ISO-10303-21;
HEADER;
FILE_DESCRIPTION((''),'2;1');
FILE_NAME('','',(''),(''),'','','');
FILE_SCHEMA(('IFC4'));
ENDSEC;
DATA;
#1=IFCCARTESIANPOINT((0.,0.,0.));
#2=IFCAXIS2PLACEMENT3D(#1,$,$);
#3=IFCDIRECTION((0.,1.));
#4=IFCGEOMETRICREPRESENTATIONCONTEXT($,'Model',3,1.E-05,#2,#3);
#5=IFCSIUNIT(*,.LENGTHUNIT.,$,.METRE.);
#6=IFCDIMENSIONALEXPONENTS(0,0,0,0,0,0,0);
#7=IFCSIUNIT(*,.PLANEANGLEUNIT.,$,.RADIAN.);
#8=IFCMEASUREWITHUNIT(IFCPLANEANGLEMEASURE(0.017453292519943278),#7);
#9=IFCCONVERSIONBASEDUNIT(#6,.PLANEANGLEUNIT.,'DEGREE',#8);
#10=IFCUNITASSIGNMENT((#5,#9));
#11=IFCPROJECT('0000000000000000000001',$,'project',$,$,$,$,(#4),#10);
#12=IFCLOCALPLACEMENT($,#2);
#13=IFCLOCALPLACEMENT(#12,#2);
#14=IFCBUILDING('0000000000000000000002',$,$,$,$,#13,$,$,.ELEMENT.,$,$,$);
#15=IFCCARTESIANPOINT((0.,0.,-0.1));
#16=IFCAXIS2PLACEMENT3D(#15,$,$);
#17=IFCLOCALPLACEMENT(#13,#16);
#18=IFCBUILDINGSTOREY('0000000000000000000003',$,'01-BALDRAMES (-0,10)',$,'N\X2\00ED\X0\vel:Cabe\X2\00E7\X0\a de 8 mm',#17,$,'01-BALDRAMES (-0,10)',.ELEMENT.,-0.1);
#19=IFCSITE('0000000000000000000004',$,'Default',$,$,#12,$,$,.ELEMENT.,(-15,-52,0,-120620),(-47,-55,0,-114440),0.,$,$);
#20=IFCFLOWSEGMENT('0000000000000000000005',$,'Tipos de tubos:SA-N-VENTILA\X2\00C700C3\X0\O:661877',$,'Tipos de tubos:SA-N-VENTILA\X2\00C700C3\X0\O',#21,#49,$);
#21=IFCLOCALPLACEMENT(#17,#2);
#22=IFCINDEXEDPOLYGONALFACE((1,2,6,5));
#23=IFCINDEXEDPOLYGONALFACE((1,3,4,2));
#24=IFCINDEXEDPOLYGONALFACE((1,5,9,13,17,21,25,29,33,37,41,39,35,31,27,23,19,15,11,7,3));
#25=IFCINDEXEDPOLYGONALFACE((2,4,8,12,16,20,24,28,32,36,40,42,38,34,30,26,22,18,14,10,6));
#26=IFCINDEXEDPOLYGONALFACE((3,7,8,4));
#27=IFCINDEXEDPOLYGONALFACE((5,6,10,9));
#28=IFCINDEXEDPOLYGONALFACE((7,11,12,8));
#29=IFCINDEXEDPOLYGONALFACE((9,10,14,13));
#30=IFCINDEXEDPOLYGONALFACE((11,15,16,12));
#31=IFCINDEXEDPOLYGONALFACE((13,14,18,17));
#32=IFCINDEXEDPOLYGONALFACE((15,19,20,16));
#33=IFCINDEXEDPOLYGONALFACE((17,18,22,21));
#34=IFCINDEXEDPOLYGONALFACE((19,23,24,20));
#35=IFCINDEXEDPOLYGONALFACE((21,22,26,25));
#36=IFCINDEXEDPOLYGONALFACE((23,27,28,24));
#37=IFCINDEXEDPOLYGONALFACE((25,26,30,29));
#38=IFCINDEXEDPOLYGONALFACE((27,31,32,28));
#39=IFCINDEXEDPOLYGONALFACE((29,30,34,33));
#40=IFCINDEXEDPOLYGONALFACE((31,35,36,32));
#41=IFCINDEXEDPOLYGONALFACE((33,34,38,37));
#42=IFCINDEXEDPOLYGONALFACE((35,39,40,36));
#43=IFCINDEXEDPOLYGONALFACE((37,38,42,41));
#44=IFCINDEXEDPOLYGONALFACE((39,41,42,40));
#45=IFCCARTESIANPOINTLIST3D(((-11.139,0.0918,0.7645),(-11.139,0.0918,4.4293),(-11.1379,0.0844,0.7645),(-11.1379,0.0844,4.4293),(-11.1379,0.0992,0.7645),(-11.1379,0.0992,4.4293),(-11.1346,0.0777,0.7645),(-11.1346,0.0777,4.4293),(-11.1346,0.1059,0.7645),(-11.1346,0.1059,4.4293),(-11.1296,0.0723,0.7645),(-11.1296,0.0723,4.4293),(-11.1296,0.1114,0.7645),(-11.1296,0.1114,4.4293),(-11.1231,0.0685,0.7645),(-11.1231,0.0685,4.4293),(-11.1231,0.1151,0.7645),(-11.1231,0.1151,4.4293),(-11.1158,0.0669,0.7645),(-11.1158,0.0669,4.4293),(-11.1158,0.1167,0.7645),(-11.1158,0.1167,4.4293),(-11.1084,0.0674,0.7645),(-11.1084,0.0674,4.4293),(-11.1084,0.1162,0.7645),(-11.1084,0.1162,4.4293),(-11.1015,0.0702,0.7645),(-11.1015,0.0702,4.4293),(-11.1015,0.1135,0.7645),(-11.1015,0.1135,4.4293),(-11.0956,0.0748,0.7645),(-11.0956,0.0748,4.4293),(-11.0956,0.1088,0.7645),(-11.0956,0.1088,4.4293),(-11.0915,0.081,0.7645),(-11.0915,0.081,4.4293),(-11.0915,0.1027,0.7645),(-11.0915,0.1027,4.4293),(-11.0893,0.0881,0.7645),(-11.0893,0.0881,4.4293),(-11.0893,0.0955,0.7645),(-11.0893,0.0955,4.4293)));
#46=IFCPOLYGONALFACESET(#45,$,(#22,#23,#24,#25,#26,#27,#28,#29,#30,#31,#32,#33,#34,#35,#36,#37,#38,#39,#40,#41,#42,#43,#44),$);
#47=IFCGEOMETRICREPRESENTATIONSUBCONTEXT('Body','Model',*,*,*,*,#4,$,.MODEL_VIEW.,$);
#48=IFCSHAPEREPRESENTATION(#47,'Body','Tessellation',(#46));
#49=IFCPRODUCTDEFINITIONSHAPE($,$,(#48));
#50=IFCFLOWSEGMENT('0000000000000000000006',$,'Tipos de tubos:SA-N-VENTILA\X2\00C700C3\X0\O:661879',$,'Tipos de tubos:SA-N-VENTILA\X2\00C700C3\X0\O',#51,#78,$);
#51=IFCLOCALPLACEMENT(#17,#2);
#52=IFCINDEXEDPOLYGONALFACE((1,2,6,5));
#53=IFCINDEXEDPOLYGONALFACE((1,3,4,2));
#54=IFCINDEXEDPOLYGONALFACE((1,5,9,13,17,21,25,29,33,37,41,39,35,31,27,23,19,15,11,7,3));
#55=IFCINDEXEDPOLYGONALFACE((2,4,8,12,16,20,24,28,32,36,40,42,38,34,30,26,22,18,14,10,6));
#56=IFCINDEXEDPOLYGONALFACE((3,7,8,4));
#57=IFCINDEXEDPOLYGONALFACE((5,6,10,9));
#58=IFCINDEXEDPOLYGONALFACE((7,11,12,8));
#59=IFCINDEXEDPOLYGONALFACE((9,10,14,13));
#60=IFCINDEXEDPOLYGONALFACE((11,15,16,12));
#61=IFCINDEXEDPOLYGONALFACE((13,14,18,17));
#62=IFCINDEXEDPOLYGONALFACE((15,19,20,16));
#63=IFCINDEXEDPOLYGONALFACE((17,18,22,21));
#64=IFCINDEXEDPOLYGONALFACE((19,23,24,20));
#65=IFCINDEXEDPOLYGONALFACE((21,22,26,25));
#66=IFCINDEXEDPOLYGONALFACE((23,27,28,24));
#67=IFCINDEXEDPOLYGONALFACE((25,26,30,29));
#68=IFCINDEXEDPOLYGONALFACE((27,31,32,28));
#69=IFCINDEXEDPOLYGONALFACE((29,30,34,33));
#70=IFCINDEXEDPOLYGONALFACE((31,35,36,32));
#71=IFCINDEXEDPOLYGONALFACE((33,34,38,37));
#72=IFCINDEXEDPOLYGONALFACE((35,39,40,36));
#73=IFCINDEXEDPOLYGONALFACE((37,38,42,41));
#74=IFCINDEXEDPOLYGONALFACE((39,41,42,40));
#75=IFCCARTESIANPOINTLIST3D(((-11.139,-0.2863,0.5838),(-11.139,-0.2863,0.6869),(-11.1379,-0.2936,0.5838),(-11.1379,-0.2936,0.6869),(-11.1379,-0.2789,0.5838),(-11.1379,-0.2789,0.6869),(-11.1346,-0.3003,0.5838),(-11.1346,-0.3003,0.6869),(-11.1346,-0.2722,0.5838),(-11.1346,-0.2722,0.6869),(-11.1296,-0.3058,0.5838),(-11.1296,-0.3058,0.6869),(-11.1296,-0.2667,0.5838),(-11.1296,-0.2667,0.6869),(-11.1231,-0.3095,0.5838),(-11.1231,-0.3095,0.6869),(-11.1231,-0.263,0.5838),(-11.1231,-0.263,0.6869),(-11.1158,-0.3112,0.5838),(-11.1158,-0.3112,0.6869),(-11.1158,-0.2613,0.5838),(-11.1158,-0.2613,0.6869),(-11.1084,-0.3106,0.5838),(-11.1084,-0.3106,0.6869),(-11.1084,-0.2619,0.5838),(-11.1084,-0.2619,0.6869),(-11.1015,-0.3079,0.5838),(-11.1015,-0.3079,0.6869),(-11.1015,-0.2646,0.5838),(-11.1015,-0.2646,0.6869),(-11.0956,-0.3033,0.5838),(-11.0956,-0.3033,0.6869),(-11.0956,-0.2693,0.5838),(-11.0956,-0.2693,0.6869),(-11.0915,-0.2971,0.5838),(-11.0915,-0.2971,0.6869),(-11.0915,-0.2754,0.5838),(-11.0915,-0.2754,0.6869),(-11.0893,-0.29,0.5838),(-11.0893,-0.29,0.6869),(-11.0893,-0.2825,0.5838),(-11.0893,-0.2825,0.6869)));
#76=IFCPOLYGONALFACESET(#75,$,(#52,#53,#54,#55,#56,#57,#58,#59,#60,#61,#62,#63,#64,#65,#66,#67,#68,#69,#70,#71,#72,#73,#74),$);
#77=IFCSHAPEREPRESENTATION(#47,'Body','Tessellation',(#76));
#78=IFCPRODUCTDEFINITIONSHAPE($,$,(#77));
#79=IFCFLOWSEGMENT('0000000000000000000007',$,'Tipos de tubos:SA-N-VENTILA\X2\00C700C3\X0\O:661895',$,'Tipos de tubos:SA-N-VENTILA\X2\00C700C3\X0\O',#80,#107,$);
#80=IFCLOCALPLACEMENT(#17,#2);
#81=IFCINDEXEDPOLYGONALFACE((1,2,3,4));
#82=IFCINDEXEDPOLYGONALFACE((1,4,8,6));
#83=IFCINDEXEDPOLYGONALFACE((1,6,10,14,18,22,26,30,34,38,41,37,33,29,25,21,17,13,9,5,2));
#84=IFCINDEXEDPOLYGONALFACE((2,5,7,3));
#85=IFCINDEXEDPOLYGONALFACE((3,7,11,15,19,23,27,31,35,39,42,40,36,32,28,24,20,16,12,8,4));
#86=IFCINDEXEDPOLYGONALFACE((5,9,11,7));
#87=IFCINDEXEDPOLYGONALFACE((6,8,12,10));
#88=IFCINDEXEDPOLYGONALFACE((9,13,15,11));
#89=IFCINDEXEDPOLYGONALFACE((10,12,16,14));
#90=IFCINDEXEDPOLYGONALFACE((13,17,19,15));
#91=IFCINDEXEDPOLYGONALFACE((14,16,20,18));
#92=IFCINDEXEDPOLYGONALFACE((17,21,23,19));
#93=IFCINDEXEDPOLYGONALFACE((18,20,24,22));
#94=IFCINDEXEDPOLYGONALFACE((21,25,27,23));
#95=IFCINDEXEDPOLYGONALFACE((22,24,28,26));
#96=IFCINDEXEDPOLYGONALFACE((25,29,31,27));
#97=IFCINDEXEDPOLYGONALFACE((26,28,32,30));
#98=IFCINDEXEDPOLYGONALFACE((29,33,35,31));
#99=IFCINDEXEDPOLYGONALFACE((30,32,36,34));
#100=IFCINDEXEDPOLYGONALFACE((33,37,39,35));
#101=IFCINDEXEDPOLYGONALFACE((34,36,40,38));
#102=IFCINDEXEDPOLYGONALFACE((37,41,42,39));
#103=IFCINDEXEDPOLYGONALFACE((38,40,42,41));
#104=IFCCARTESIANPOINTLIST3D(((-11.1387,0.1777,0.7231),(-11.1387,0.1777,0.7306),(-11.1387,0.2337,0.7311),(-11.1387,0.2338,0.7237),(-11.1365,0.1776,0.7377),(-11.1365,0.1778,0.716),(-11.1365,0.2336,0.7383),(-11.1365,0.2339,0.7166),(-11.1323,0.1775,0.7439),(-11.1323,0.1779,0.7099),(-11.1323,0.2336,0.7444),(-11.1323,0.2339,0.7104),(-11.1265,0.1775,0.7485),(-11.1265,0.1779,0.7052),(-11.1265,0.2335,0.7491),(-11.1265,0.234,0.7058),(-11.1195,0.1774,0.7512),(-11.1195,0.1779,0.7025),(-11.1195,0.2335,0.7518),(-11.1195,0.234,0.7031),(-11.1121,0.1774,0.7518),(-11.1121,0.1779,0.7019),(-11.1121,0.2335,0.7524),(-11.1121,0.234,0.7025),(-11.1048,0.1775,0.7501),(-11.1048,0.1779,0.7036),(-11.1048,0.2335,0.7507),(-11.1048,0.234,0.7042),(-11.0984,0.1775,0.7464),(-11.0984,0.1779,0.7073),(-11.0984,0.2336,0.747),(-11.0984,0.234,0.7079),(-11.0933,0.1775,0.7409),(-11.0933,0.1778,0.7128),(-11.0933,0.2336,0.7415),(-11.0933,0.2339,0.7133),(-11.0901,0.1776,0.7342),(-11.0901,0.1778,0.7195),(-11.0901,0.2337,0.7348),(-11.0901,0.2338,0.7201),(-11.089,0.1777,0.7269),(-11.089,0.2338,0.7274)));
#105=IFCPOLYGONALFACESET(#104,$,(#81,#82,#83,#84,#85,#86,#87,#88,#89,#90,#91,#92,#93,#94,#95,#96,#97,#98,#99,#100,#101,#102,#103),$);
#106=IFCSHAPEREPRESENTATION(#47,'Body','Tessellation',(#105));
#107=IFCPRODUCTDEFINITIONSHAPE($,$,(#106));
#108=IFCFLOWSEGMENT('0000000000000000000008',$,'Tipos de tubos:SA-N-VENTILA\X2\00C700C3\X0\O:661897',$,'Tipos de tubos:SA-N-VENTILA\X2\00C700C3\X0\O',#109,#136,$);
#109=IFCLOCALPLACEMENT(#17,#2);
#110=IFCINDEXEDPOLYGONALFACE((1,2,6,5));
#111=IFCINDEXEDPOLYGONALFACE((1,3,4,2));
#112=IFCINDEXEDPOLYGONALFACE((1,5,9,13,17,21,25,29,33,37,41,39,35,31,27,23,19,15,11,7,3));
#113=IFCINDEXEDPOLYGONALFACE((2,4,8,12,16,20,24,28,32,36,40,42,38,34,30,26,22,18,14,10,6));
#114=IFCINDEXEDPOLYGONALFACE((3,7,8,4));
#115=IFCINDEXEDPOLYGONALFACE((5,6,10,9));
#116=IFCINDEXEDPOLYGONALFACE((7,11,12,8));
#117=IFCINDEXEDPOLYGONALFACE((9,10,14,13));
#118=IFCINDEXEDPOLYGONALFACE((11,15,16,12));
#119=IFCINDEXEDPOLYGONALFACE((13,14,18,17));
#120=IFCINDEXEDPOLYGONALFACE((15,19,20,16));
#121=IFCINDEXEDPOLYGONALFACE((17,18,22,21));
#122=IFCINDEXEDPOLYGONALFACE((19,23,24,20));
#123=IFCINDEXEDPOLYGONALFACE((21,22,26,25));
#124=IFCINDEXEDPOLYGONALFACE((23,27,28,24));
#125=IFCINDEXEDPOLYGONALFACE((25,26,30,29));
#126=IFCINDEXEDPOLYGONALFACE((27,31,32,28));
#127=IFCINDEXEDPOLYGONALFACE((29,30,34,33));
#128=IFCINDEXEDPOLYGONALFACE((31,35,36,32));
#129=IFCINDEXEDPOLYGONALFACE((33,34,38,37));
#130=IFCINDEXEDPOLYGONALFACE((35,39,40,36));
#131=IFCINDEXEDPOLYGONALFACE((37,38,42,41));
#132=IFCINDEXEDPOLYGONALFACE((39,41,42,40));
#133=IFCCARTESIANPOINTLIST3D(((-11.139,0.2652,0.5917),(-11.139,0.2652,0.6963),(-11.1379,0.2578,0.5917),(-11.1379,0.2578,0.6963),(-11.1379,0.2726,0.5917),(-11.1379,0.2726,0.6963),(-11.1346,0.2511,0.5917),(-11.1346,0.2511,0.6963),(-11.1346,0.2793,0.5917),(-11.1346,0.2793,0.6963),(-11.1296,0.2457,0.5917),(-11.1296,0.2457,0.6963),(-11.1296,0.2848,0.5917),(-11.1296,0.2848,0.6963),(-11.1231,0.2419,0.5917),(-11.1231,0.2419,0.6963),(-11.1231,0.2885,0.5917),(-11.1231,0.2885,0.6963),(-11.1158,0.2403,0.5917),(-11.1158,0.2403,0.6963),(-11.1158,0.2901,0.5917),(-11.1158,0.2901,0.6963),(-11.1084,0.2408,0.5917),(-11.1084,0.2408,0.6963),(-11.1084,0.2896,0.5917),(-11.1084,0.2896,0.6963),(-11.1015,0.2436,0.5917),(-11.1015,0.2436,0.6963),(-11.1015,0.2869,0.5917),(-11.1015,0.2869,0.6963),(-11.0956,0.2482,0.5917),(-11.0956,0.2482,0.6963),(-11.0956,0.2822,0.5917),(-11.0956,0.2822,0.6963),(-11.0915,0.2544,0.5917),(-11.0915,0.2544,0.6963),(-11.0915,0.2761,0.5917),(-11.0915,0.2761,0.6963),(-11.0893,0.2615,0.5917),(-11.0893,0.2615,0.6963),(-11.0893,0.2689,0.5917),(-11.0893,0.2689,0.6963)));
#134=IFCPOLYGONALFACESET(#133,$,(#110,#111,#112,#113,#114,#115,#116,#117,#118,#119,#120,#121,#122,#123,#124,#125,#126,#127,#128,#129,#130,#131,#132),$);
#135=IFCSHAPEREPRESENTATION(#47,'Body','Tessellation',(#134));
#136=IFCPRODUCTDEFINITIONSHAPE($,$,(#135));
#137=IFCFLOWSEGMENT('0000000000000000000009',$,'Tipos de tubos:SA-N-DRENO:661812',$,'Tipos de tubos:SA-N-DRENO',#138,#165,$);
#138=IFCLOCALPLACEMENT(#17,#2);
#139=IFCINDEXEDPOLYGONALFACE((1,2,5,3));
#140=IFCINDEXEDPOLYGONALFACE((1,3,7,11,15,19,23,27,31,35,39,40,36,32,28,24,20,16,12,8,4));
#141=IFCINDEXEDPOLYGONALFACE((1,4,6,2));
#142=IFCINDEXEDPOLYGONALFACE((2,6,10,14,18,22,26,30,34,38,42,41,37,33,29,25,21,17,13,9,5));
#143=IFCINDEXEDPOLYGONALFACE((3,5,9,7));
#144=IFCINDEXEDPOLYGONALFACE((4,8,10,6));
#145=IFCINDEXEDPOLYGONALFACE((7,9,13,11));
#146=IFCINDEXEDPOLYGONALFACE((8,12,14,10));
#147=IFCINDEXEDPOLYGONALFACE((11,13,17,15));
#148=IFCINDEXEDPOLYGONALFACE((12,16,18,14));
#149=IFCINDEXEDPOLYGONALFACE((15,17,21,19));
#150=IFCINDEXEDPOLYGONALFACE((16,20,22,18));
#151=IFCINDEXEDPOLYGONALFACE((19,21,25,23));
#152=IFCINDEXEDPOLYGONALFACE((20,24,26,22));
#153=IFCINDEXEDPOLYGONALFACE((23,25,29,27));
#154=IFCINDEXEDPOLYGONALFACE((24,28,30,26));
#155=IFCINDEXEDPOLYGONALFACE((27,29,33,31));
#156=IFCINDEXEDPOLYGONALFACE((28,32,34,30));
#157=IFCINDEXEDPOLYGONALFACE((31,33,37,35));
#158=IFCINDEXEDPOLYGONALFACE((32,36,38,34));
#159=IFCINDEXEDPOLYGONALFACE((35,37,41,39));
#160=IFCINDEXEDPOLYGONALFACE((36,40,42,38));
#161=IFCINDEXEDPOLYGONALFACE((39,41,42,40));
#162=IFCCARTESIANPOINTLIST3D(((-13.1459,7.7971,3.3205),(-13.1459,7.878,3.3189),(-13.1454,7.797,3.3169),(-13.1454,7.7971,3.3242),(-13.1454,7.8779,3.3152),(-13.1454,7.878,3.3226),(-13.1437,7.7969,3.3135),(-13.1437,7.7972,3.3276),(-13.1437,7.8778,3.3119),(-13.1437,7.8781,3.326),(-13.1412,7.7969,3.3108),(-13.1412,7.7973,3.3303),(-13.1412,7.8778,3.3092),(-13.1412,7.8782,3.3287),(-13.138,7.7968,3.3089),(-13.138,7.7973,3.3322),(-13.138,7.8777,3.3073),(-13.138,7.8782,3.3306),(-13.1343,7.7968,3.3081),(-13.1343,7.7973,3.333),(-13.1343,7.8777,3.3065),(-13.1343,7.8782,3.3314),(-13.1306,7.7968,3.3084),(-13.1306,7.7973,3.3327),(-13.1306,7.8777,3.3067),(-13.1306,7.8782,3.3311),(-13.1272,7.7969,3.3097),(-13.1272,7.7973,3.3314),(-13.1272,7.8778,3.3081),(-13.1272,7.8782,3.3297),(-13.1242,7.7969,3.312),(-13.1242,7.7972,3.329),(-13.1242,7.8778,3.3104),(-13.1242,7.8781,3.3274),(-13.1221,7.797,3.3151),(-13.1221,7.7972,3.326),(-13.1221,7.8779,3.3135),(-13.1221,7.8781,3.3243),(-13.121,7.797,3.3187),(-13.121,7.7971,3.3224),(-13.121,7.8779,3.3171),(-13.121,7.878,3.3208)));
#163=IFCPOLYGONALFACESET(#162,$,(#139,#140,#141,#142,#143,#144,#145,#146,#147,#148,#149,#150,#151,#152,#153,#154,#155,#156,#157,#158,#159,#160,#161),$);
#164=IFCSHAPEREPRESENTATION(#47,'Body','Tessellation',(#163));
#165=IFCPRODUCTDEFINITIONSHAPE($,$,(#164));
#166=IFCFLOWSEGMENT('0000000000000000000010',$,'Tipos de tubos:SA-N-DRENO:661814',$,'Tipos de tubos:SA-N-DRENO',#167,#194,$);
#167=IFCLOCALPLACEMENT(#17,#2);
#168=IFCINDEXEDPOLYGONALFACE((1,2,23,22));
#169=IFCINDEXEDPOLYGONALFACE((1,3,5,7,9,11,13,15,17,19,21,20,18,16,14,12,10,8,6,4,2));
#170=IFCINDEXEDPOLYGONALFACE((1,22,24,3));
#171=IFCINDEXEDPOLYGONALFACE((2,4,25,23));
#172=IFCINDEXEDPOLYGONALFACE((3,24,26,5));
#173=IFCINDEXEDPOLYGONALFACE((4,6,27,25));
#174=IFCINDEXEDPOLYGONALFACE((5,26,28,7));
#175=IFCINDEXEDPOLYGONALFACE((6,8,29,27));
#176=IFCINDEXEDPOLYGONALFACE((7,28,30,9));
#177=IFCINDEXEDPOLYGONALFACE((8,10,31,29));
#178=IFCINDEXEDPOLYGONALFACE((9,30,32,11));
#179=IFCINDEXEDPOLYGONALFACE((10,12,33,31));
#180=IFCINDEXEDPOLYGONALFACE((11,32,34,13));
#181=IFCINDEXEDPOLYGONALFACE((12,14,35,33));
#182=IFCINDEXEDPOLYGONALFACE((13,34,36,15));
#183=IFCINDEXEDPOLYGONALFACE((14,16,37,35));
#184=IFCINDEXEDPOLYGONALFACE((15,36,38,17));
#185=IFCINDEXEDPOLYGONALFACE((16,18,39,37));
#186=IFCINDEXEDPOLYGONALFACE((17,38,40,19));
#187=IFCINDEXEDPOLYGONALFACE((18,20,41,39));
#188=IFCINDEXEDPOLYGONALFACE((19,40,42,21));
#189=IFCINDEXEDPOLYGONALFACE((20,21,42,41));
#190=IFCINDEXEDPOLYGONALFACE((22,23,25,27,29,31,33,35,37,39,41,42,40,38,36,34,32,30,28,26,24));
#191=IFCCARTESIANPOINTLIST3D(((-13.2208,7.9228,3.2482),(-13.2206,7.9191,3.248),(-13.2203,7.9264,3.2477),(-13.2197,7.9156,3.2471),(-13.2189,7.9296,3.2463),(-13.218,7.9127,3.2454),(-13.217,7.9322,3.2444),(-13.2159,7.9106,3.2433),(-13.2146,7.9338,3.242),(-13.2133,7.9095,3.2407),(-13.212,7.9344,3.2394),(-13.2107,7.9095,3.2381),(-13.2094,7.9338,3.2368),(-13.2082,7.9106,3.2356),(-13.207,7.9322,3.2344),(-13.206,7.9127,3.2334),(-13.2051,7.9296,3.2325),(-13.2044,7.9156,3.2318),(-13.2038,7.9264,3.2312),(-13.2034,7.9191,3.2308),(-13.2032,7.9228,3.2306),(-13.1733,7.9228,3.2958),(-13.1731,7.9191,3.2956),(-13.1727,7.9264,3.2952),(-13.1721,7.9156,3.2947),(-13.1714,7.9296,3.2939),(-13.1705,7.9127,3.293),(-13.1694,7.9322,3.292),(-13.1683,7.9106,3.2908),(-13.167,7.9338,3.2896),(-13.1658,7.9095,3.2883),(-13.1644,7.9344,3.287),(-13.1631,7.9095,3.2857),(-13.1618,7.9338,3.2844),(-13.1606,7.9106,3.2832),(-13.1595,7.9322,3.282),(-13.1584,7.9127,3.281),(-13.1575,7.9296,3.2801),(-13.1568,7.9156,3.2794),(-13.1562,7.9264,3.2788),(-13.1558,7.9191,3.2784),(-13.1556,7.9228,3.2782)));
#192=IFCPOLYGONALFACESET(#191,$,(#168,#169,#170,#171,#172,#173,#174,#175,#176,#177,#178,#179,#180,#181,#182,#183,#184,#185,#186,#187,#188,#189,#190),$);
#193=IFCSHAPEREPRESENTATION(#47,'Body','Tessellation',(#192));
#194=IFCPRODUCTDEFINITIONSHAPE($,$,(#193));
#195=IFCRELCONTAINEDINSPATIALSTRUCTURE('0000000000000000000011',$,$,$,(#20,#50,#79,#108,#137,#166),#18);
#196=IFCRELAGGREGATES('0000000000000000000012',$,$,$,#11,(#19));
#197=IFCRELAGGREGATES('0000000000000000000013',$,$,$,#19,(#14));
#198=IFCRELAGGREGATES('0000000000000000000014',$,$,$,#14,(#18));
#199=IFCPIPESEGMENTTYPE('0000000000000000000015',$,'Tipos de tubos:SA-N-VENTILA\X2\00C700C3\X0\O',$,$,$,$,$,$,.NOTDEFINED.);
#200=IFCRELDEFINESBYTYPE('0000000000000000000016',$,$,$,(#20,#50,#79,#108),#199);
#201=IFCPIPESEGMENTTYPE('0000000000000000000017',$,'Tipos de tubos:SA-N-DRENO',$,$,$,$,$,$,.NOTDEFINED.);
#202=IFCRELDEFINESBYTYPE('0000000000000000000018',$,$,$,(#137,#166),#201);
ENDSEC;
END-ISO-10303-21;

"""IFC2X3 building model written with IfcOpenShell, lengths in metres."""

from ifc_helpers import new_model, entity, si_unit, converted_unit, direction, frame, frame_2d, origin, place, context, subcontext, project, spatial, circle, extrude, type_object, element, save


model = new_model("IFC2X3")

# Units and contexts
model_context = context("Model", 3, precision=1e-05, world=origin(), true_north=direction((0.0, 1.0)))
body_context = subcontext(model_context, "Body", "Model", "MODEL_VIEW")
ifc_project = project(units=[si_unit("LENGTHUNIT", "METRE"), converted_unit("PLANEANGLEUNIT", "DEGREE", entity("IfcPlaneAngleMeasure", 0.017453292519943278), si_unit("PLANEANGLEUNIT", "RADIAN"), dimensions=[0, 0, 0, 0, 0, 0, 0])], contexts=[model_context])

# Site, building, storey
site_placement = place(None, origin())
site = spatial("IfcSite", under=ifc_project, at=site_placement, Name="Default", CompositionType="ELEMENT", RefLatitude=(-15, -52, 0, -120620), RefLongitude=(-47, -55, 0, -114440), RefElevation=0.0)
building_placement = place(site_placement, origin())
building = spatial("IfcBuilding", under=site, at=building_placement, CompositionType="ELEMENT")
storey_placement = place(building_placement, frame((0.0, 0.0, -0.1)))
storey = spatial("IfcBuildingStorey", under=building, at=storey_placement, Name="01-BALDRAMES (-0,10)", ObjectType="Nível:Cabeça de 8 mm", LongName="01-BALDRAMES (-0,10)", CompositionType="ELEMENT", Elevation=-0.1)

# Flow segments
pipe_segment_type_1 = type_object("IfcPipeSegmentType", Name="Tipos de tubos:SA-N-VENTILAÇÃO", PredefinedType="NOTDEFINED")
flow_segment_1_placement = place(storey_placement, origin())
element("IfcFlowSegment", 1, at=flow_segment_1_placement, inside=storey, type_object=pipe_segment_type_1, Name="Tipos de tubos:SA-N-VENTILAÇÃO:661877", ObjectType="Tipos de tubos:SA-N-VENTILAÇÃO", context=body_context, shape_type="SweptSolid", body=[
    extrude(circle(Radius=0.025, at=frame_2d((0.0, 0.0), x_axis=(1.0, 0.0))), frame((-11.114, 0.0918, 0.7645), z_axis=(0.0, 0.0, 1.0), x_axis=(-1.0, 0.0, 0.0)), (0.0, 0.0, 1.0), 3.6648),
])
flow_segment_2_placement = place(storey_placement, origin())
element("IfcFlowSegment", 2, at=flow_segment_2_placement, inside=storey, type_object=pipe_segment_type_1, Name="Tipos de tubos:SA-N-VENTILAÇÃO:661879", ObjectType="Tipos de tubos:SA-N-VENTILAÇÃO", context=body_context, shape_type="SweptSolid", body=[
    extrude(circle(Radius=0.025, at=frame_2d((0.0, 0.0), x_axis=(1.0, 0.0))), frame((-11.114, -0.2863, 0.5838), z_axis=(0.0, 0.0, 1.0), x_axis=(-1.0, 0.0, 0.0)), (0.0, 0.0, 1.0), 0.1031),
])
flow_segment_3_placement = place(storey_placement, origin())
element("IfcFlowSegment", 3, at=flow_segment_3_placement, inside=storey, type_object=pipe_segment_type_1, Name="Tipos de tubos:SA-N-VENTILAÇÃO:661895", ObjectType="Tipos de tubos:SA-N-VENTILAÇÃO", context=body_context, shape_type="SweptSolid", body=[
    extrude(circle(Radius=0.025, at=frame_2d((0.0, 0.0), x_axis=(1.0, 0.0))), frame((-11.114, 0.1777, 0.7269), z_axis=(-0.000001, 0.99995, 0.01), x_axis=(1.0, 0.000001, 0.0)), (0.0, 0.0, 1.0), 0.0561),
])
flow_segment_4_placement = place(storey_placement, origin())
element("IfcFlowSegment", 4, at=flow_segment_4_placement, inside=storey, type_object=pipe_segment_type_1, Name="Tipos de tubos:SA-N-VENTILAÇÃO:661897", ObjectType="Tipos de tubos:SA-N-VENTILAÇÃO", context=body_context, shape_type="SweptSolid", body=[
    extrude(circle(Radius=0.025, at=frame_2d((0.0, 0.0), x_axis=(1.0, 0.0))), frame((-11.114, 0.2652, 0.5917), z_axis=(0.0, 0.0, 1.0), x_axis=(-1.0, 0.0, 0.0)), (0.0, 0.0, 1.0), 0.1046),
])
pipe_segment_type_2 = type_object("IfcPipeSegmentType", Name="Tipos de tubos:SA-N-DRENO", PredefinedType="NOTDEFINED")
flow_segment_5_placement = place(storey_placement, origin())
element("IfcFlowSegment", 5, at=flow_segment_5_placement, inside=storey, type_object=pipe_segment_type_2, Name="Tipos de tubos:SA-N-DRENO:661812", ObjectType="Tipos de tubos:SA-N-DRENO", context=body_context, shape_type="SweptSolid", body=[
    extrude(circle(Radius=0.0125, at=frame_2d((0.0, 0.0), x_axis=(1.0, 0.0))), frame((-13.1334, 7.7971, 3.3205), z_axis=(-0.000001, 0.9998, -0.019996), x_axis=(-1.0, -0.000001, 0.0)), (0.0, 0.0, 1.0), 0.0809),
])
flow_segment_6_placement = place(storey_placement, origin())
element("IfcFlowSegment", 6, at=flow_segment_6_placement, inside=storey, type_object=pipe_segment_type_2, Name="Tipos de tubos:SA-N-DRENO:661814", ObjectType="Tipos de tubos:SA-N-DRENO", context=body_context, shape_type="SweptSolid", body=[
    extrude(circle(Radius=0.0125, at=frame_2d((0.0, 0.0), x_axis=(1.0, 0.0))), frame((-13.212, 7.9219, 3.2394), z_axis=(0.707107, 0.000001, 0.707107), x_axis=(-0.000001, 1.0, 0.0)), (0.0, 0.0, 1.0), 0.0673),
])

save(model, "model.ifc")
